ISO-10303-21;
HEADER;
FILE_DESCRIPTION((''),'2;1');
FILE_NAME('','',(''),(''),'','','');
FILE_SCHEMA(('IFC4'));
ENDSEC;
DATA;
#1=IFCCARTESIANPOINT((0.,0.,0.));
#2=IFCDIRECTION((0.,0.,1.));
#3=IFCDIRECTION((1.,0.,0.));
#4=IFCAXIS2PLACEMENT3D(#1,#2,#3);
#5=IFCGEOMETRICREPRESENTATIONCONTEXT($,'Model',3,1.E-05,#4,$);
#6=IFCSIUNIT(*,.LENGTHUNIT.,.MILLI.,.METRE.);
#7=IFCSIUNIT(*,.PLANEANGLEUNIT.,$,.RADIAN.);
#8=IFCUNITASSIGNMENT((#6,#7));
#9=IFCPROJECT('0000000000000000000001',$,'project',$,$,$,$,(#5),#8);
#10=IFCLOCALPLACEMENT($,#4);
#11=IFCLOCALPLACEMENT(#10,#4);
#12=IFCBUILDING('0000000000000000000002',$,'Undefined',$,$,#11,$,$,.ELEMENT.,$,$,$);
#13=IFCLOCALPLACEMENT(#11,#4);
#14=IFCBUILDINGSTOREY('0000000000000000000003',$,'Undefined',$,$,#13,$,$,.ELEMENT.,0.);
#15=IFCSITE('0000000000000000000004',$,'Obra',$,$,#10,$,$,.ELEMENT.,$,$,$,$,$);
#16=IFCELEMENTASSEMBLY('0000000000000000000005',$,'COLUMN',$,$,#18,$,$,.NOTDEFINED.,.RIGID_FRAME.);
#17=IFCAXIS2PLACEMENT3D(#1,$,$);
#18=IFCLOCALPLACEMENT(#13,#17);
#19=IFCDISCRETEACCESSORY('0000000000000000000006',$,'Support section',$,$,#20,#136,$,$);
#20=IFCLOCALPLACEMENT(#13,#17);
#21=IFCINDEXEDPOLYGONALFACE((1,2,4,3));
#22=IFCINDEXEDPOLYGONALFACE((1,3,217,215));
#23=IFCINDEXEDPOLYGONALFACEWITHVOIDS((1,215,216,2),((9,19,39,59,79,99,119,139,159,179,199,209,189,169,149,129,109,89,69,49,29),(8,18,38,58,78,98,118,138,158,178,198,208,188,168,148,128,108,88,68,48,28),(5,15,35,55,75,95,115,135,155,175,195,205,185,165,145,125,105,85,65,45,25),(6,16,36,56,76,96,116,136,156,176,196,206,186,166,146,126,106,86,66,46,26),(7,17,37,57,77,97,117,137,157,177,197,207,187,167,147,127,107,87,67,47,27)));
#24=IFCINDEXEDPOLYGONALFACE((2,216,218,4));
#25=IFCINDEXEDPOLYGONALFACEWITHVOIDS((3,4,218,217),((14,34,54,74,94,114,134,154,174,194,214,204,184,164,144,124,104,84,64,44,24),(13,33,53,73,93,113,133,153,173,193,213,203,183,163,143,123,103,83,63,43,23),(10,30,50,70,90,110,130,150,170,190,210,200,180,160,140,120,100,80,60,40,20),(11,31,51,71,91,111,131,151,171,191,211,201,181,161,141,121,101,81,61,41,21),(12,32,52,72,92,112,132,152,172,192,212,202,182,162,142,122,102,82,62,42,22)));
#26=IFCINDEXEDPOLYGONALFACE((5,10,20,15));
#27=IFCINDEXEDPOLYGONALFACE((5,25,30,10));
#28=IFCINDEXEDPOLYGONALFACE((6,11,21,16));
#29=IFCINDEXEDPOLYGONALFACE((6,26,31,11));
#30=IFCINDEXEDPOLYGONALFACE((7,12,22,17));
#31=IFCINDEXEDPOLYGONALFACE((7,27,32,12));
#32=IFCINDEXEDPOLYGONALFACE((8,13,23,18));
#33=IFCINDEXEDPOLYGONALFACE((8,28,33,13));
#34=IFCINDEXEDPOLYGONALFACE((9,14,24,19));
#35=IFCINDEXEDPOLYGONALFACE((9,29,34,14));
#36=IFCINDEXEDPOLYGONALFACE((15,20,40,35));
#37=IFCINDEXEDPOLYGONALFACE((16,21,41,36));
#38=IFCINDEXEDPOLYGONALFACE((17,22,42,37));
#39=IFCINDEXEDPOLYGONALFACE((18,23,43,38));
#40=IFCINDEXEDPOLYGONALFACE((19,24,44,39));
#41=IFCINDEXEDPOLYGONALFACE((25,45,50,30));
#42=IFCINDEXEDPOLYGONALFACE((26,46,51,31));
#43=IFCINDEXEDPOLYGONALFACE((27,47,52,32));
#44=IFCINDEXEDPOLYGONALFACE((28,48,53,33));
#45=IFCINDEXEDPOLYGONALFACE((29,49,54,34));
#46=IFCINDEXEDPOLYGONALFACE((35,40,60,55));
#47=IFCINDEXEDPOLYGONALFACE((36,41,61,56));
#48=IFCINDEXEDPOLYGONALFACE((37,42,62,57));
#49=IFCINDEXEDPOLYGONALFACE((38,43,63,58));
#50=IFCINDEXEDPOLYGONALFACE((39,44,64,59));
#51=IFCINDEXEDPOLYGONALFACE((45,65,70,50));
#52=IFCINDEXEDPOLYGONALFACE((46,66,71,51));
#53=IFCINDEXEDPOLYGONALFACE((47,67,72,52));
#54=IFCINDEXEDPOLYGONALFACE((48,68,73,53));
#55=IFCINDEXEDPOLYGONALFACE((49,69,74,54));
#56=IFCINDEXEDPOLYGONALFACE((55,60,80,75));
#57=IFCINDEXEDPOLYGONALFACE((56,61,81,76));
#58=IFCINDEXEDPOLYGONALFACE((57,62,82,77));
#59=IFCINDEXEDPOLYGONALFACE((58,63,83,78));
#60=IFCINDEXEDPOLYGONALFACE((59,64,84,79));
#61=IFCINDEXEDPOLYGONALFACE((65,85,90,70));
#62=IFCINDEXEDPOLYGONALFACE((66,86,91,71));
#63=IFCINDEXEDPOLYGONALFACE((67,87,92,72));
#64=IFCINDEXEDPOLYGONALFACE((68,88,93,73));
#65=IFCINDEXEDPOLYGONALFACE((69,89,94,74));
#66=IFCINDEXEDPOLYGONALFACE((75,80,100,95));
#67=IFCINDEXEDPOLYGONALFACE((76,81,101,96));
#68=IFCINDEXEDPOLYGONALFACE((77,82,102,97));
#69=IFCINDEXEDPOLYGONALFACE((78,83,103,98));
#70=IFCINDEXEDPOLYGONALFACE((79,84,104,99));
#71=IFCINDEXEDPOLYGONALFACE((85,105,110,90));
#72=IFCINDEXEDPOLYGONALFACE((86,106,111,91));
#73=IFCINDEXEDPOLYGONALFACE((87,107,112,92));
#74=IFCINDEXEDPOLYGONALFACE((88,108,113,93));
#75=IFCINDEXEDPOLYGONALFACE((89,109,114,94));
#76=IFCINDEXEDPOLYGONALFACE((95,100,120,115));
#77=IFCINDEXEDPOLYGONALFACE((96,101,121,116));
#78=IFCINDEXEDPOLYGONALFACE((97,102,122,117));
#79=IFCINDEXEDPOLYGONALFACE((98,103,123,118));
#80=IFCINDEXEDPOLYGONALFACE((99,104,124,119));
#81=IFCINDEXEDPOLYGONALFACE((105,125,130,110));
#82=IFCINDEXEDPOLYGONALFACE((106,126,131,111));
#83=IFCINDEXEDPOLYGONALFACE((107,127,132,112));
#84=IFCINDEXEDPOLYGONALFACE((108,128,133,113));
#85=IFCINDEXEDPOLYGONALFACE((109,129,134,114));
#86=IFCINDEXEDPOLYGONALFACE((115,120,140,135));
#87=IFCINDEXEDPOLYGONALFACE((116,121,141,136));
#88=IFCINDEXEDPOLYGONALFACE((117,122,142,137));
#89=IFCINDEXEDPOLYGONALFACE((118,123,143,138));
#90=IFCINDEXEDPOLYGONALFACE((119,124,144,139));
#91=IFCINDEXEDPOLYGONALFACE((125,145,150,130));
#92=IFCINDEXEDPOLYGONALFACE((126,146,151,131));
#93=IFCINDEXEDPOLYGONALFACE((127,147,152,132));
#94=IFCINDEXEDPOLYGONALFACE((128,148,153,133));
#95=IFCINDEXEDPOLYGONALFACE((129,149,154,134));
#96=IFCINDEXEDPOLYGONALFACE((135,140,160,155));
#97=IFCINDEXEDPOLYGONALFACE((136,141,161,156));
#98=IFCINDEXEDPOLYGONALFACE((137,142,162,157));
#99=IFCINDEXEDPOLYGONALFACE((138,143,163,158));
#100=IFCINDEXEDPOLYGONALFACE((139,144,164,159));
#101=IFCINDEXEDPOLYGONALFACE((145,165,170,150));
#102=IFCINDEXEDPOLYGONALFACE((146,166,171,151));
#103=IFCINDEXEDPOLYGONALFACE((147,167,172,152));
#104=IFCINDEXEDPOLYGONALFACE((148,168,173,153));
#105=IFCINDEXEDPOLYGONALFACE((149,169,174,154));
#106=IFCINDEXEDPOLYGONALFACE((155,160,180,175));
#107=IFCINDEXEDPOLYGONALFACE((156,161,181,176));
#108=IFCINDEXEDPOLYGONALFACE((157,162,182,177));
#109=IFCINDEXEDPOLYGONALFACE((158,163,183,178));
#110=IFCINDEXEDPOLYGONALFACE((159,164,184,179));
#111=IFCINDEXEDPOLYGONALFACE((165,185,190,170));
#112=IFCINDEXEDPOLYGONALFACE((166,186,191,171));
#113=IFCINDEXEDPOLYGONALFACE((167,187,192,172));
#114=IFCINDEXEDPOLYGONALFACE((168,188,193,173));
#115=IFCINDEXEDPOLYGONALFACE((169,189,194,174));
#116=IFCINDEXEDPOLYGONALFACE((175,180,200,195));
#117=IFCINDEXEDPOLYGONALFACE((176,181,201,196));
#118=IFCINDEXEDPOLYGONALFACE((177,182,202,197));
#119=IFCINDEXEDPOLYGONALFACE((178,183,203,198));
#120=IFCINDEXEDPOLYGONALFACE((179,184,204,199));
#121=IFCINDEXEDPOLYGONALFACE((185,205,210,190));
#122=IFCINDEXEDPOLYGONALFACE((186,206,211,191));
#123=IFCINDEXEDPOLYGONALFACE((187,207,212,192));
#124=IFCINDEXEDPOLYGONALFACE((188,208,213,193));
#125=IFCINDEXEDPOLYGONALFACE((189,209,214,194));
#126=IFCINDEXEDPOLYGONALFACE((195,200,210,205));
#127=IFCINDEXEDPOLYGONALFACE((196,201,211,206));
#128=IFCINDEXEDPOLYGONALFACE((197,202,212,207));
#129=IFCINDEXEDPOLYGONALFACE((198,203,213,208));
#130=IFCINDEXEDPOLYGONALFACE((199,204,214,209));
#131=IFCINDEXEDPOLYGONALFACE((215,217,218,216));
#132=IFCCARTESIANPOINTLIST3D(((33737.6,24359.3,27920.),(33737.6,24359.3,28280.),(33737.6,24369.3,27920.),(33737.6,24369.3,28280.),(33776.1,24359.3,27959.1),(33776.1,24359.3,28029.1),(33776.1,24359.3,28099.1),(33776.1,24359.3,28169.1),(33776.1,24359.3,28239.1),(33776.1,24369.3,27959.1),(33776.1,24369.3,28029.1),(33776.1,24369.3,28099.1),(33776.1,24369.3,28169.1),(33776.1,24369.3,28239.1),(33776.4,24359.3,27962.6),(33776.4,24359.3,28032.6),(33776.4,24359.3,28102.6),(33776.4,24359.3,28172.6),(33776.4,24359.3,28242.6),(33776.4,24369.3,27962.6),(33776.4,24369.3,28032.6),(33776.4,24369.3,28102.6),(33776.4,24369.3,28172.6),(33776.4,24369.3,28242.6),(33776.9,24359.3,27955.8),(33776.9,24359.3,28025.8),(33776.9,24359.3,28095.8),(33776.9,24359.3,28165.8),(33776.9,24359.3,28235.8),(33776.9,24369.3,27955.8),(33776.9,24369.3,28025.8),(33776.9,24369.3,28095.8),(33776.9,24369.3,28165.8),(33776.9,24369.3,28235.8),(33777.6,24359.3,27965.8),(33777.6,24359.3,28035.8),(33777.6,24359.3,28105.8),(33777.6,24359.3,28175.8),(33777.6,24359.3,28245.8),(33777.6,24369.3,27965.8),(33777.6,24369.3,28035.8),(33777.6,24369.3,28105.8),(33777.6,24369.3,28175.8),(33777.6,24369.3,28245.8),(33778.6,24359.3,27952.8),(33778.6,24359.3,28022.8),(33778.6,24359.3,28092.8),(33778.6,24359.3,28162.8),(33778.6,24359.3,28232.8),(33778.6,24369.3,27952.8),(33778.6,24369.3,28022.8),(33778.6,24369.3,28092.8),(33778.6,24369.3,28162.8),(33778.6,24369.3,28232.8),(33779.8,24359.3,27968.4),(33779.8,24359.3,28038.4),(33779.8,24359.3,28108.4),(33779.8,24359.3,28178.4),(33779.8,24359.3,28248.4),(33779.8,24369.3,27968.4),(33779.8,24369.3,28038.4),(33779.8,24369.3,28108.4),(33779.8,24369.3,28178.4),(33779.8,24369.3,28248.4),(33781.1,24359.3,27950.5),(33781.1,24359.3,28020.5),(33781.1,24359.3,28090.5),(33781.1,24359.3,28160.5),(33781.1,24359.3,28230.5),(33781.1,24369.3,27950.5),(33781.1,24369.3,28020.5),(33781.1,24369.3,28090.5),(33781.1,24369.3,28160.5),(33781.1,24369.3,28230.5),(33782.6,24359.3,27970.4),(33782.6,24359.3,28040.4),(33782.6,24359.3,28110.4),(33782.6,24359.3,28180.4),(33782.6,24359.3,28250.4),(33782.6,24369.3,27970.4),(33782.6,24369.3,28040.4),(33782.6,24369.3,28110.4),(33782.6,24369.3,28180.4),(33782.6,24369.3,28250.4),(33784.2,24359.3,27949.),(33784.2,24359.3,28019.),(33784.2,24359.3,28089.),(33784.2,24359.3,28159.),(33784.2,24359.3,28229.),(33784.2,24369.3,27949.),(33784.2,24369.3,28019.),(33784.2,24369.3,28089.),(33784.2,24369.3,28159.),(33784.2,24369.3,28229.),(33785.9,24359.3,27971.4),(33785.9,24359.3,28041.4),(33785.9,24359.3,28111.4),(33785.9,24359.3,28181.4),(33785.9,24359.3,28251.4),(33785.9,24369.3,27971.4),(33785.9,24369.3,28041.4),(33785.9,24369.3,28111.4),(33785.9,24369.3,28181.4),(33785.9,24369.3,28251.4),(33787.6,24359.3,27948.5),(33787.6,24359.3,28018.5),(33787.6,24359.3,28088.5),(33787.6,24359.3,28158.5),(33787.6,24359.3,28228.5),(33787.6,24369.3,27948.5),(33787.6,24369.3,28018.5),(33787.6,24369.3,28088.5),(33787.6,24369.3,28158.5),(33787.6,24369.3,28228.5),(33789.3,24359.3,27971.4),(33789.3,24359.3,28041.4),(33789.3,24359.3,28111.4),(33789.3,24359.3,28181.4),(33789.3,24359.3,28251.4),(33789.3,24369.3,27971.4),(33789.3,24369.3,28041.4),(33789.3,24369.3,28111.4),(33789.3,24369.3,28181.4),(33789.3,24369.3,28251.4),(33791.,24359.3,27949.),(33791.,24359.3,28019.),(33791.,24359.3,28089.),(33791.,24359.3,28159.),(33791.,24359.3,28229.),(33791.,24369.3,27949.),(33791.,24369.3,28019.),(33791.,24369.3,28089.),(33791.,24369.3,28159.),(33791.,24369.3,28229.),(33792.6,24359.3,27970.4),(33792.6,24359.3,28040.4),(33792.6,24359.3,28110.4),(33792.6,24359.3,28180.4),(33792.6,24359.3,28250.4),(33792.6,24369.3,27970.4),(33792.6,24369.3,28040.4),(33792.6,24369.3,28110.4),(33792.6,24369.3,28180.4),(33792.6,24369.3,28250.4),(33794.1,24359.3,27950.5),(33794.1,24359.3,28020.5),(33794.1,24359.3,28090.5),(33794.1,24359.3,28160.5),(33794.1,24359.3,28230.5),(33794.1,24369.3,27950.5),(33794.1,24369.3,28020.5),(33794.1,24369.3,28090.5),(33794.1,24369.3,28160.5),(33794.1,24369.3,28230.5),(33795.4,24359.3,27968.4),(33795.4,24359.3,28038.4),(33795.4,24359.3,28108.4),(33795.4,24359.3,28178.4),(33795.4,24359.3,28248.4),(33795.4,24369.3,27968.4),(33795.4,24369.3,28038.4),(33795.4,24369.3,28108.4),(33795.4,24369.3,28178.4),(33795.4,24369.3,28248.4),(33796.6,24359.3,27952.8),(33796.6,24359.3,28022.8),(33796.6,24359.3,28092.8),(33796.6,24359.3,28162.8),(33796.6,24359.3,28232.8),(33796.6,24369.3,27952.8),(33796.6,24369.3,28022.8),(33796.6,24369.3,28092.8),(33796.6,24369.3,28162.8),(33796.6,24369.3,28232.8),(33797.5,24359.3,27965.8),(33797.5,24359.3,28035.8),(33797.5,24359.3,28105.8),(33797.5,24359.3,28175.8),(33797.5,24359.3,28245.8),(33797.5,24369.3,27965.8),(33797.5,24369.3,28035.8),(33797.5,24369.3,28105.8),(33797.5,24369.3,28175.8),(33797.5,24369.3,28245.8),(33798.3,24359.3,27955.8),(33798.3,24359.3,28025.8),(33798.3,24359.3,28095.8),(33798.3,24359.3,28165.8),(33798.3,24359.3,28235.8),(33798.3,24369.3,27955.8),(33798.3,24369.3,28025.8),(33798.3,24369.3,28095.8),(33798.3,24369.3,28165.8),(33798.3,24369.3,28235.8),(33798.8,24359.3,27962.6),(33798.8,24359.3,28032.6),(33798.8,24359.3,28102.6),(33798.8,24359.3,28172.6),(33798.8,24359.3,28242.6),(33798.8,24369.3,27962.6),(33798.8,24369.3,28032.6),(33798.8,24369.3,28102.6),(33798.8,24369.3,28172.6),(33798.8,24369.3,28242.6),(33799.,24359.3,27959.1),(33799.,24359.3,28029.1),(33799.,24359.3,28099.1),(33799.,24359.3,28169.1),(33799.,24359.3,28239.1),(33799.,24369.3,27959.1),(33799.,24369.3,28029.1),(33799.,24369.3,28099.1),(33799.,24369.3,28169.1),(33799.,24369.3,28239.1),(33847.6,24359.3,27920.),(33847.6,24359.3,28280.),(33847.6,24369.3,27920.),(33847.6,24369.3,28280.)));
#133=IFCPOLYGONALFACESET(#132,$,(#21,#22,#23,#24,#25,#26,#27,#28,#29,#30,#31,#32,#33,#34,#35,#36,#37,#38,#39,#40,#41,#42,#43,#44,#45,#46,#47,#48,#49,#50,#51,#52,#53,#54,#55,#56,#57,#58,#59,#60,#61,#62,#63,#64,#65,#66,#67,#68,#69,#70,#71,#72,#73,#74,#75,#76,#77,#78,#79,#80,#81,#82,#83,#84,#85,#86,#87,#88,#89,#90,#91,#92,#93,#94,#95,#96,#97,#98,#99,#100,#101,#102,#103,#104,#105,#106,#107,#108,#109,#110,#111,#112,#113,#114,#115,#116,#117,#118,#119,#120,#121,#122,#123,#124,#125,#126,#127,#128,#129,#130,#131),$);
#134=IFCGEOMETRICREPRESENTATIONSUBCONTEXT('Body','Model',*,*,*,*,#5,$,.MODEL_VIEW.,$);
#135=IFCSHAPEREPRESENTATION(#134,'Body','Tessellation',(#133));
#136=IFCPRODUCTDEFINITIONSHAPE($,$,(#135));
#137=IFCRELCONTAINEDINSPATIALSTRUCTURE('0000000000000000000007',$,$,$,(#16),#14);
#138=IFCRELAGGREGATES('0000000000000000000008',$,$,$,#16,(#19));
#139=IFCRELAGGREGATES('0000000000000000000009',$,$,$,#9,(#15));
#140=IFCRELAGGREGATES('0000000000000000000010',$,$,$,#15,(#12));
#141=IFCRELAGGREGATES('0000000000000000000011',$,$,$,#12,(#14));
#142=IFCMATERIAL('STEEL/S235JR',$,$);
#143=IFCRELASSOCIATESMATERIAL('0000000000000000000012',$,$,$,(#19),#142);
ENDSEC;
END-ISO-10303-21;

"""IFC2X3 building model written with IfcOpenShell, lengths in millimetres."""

from ifc_helpers import new_model, si_unit, frame, origin_with_axes, origin_2d_with_axis, place, context, subcontext, project, spatial, rectangle, circle, extrude, source, transform, mapped, material, element, aggregate, save


model = new_model("IFC2X3")

# Units and contexts
model_context = context("Model", 3, precision=1e-05, world=origin_with_axes())
body_context = subcontext(model_context, "Body", "Model", "MODEL_VIEW")
ifc_project = project(units=[si_unit("LENGTHUNIT", "METRE", prefix="MILLI"), si_unit("PLANEANGLEUNIT", "RADIAN")], contexts=[model_context])

# Site, building, storey
site_placement = place(None, origin_with_axes())
site = spatial("IfcSite", under=ifc_project, at=site_placement, Name="Obra", CompositionType="ELEMENT")
building_placement = place(site_placement, origin_with_axes())
building = spatial("IfcBuilding", under=site, at=building_placement, Name="Undefined", CompositionType="ELEMENT")
storey_placement = place(building_placement, origin_with_axes())
storey = spatial("IfcBuildingStorey", under=building, at=storey_placement, Name="Undefined", CompositionType="ELEMENT", Elevation=0.0)

# Shared definitions
ifc_material_1 = material(Name="STEEL/S235JR")

# Element assembly, discrete accessory, opening
assembly_1_placement = place(storey_placement, origin_with_axes())
assembly_1 = element("IfcElementAssembly", 1, at=assembly_1_placement, inside=storey, Name="COLUMN", AssemblyPlace="NOTDEFINED", PredefinedType="RIGID_FRAME")
shared_shape_1 = source(origin_with_axes(), body_context, "Body", "SweptSolid", [
    extrude(circle(Radius=11.5, at=origin_2d_with_axis()), frame((0.0, -14.4, 0.0), z_axis=(0.0, 1.0, 0.0), x_axis=(1.0, 0.0, 0.0)), (0.0, 0.0, 1.0), 10.2),
])
discrete_accessory_1_placement = place(assembly_1_placement, frame((33792.6, 24364.3, 27920.0), z_axis=(0.0, 0.0, 1.0), x_axis=(1.0, 0.0, 0.0)))
discrete_accessory_1 = element("IfcDiscreteAccessory", 2, at=discrete_accessory_1_placement, material=ifc_material_1, Name="Support section", context=body_context, shape_type="SweptSolid", body=[
    extrude(rectangle(XDim=10.0, YDim=110.0, at=origin_2d_with_axis()), frame((0.0, 0.0, 360.0), z_axis=(0.0, 0.0, -1.0), x_axis=(0.0, 1.0, 0.0)), (0.0, 0.0, 1.0), 360.0),
])
opening_1_placement = place(assembly_1_placement, frame((33837.6, 24355.0, 28300.0), z_axis=(-1.0, 0.0, 0.0), x_axis=(0.0, 0.0, -1.0)))
element("IfcOpeningElement", 3, at=opening_1_placement, cuts=discrete_accessory_1, ObjectType="Opening", context=body_context, shape_type="MappedRepresentation", body=[
    mapped(shared_shape_1, transform((60.0, 0.0, 50.0))),
    mapped(shared_shape_1, transform((130.0, 0.0, 50.0))),
    mapped(shared_shape_1, transform((200.0, 0.0, 50.0))),
    mapped(shared_shape_1, transform((270.0, 0.0, 50.0))),
    mapped(shared_shape_1, transform((340.0, 0.0, 50.0))),
])
aggregate(assembly_1, [discrete_accessory_1])

save(model, "model.ifc")
